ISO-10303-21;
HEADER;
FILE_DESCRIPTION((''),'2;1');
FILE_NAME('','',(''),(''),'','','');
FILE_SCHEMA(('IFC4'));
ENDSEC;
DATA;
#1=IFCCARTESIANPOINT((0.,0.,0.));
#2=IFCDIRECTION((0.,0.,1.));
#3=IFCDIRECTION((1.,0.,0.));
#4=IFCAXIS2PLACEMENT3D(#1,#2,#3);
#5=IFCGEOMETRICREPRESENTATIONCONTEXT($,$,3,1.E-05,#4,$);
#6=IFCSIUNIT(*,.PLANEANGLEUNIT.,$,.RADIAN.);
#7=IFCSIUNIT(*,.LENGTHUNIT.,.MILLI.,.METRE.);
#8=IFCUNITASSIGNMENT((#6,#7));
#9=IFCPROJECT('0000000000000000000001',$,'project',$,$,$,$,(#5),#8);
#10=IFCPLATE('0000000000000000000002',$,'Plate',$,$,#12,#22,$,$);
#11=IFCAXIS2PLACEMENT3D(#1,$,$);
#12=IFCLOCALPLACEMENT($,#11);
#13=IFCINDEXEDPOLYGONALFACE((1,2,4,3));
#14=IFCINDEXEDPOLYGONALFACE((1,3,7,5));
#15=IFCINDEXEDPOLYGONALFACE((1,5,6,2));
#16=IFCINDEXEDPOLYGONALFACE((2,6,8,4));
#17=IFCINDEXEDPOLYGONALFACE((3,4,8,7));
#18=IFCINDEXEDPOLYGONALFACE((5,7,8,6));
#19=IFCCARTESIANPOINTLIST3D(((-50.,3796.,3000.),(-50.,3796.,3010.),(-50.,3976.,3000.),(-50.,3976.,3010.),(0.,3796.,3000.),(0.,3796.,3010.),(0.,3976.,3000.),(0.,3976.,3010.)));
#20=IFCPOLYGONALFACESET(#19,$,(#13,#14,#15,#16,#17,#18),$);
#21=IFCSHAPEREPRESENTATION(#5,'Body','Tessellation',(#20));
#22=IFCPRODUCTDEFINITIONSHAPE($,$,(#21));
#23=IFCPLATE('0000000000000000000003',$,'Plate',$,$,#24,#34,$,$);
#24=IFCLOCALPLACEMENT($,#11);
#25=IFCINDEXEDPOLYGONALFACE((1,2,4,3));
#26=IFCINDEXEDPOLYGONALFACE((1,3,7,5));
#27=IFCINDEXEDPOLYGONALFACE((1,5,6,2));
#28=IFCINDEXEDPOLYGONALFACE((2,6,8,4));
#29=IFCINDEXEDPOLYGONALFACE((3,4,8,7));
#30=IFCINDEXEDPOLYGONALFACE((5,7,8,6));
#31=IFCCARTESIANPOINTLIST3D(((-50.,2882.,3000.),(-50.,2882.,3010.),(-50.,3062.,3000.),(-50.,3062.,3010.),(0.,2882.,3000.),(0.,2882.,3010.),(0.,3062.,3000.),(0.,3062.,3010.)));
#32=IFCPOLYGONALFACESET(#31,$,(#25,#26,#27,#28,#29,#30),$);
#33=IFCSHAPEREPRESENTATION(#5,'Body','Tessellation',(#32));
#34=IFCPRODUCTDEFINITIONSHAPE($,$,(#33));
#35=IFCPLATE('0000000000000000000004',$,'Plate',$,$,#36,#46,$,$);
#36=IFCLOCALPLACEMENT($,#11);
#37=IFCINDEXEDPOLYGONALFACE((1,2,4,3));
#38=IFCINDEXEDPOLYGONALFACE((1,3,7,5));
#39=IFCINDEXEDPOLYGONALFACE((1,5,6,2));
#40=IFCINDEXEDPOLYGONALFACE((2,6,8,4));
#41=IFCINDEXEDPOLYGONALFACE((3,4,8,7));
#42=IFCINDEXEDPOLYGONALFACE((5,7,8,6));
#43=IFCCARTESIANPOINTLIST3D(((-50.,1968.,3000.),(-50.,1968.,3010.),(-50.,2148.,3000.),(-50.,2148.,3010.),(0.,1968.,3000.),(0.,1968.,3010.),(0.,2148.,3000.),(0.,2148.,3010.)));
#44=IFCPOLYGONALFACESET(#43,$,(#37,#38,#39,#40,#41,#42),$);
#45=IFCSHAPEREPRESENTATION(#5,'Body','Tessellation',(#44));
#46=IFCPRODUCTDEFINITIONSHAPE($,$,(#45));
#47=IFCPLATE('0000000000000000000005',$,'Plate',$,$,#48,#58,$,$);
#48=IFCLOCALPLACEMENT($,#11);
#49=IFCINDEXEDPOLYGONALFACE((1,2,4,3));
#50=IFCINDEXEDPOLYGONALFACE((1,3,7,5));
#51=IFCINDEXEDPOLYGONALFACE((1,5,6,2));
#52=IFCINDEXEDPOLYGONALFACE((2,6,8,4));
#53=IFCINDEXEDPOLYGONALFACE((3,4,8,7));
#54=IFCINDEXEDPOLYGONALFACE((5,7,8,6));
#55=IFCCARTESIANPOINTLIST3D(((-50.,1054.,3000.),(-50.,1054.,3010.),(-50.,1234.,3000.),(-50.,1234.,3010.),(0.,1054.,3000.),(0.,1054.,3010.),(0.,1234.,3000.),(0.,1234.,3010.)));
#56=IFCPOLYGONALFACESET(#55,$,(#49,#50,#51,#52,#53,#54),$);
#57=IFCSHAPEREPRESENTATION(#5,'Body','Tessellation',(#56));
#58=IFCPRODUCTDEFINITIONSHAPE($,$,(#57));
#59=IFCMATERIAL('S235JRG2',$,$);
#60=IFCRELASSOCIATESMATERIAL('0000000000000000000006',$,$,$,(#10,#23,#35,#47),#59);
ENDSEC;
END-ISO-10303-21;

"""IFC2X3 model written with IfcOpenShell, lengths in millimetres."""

from ifc_helpers import new_model, si_unit, frame, origin_with_axes, place, context, project, polyline, outline, extrude, material, element, save


model = new_model("IFC2X3")

# Units and contexts
context_of_model = context(None, 3, precision=1e-05, world=origin_with_axes())
ifc_project = project(units=[si_unit("PLANEANGLEUNIT", "RADIAN"), si_unit("LENGTHUNIT", "METRE", prefix="MILLI")], contexts=[context_of_model])

# Shared definitions
ifc_material = material(Name="S235JRG2")

# Plates
placement_1 = place(None, origin_with_axes())
plate_1_placement = place(placement_1, frame((0.0, 3976.0, 3010.0), z_axis=(-1.0, 0.0, 0.0), x_axis=(0.0, 0.0, -1.0)))
element("IfcPlate", 1, at=plate_1_placement, material=ifc_material, Name="Plate", context=context_of_model, shape_type="SweptSolid", body=[
    extrude(outline(polyline([(0.0, 0.0), (180.0, 0.0), (180.0, 50.0), (0.0, 50.0), (0.0, 0.0)])), frame((0.0, 0.0, 0.0), z_axis=(1.0, 0.0, 0.0), x_axis=(0.0, 1.0, 0.0)), (0.0, 0.0, 1.0), 10.0),
])
placement_2 = place(None, origin_with_axes())
plate_2_placement = place(placement_2, frame((0.0, 3062.0, 3010.0), z_axis=(-1.0, 0.0, 0.0), x_axis=(0.0, 0.0, -1.0)))
element("IfcPlate", 2, at=plate_2_placement, material=ifc_material, Name="Plate", context=context_of_model, shape_type="SweptSolid", body=[
    extrude(outline(polyline([(0.0, 0.0), (180.0, 0.0), (180.0, 50.0), (0.0, 50.0), (0.0, 0.0)])), frame((0.0, 0.0, 0.0), z_axis=(1.0, 0.0, 0.0), x_axis=(0.0, 1.0, 0.0)), (0.0, 0.0, 1.0), 10.0),
])
placement_3 = place(None, origin_with_axes())
plate_3_placement = place(placement_3, frame((0.0, 2148.0, 3010.0), z_axis=(-1.0, 0.0, 0.0), x_axis=(0.0, 0.0, -1.0)))
element("IfcPlate", 3, at=plate_3_placement, material=ifc_material, Name="Plate", context=context_of_model, shape_type="SweptSolid", body=[
    extrude(outline(polyline([(0.0, 0.0), (180.0, 0.0), (180.0, 50.0), (0.0, 50.0), (0.0, 0.0)])), frame((0.0, 0.0, 0.0), z_axis=(1.0, 0.0, 0.0), x_axis=(0.0, 1.0, 0.0)), (0.0, 0.0, 1.0), 10.0),
])
placement_4 = place(None, origin_with_axes())
plate_4_placement = place(placement_4, frame((0.0, 1234.0, 3010.0), z_axis=(-1.0, 0.0, 0.0), x_axis=(0.0, 0.0, -1.0)))
element("IfcPlate", 4, at=plate_4_placement, material=ifc_material, Name="Plate", context=context_of_model, shape_type="SweptSolid", body=[
    extrude(outline(polyline([(0.0, 0.0), (180.0, 0.0), (180.0, 50.0), (0.0, 50.0), (0.0, 0.0)])), frame((0.0, 0.0, 0.0), z_axis=(1.0, 0.0, 0.0), x_axis=(0.0, 1.0, 0.0)), (0.0, 0.0, 1.0), 10.0),
])

save(model, "model.ifc")
